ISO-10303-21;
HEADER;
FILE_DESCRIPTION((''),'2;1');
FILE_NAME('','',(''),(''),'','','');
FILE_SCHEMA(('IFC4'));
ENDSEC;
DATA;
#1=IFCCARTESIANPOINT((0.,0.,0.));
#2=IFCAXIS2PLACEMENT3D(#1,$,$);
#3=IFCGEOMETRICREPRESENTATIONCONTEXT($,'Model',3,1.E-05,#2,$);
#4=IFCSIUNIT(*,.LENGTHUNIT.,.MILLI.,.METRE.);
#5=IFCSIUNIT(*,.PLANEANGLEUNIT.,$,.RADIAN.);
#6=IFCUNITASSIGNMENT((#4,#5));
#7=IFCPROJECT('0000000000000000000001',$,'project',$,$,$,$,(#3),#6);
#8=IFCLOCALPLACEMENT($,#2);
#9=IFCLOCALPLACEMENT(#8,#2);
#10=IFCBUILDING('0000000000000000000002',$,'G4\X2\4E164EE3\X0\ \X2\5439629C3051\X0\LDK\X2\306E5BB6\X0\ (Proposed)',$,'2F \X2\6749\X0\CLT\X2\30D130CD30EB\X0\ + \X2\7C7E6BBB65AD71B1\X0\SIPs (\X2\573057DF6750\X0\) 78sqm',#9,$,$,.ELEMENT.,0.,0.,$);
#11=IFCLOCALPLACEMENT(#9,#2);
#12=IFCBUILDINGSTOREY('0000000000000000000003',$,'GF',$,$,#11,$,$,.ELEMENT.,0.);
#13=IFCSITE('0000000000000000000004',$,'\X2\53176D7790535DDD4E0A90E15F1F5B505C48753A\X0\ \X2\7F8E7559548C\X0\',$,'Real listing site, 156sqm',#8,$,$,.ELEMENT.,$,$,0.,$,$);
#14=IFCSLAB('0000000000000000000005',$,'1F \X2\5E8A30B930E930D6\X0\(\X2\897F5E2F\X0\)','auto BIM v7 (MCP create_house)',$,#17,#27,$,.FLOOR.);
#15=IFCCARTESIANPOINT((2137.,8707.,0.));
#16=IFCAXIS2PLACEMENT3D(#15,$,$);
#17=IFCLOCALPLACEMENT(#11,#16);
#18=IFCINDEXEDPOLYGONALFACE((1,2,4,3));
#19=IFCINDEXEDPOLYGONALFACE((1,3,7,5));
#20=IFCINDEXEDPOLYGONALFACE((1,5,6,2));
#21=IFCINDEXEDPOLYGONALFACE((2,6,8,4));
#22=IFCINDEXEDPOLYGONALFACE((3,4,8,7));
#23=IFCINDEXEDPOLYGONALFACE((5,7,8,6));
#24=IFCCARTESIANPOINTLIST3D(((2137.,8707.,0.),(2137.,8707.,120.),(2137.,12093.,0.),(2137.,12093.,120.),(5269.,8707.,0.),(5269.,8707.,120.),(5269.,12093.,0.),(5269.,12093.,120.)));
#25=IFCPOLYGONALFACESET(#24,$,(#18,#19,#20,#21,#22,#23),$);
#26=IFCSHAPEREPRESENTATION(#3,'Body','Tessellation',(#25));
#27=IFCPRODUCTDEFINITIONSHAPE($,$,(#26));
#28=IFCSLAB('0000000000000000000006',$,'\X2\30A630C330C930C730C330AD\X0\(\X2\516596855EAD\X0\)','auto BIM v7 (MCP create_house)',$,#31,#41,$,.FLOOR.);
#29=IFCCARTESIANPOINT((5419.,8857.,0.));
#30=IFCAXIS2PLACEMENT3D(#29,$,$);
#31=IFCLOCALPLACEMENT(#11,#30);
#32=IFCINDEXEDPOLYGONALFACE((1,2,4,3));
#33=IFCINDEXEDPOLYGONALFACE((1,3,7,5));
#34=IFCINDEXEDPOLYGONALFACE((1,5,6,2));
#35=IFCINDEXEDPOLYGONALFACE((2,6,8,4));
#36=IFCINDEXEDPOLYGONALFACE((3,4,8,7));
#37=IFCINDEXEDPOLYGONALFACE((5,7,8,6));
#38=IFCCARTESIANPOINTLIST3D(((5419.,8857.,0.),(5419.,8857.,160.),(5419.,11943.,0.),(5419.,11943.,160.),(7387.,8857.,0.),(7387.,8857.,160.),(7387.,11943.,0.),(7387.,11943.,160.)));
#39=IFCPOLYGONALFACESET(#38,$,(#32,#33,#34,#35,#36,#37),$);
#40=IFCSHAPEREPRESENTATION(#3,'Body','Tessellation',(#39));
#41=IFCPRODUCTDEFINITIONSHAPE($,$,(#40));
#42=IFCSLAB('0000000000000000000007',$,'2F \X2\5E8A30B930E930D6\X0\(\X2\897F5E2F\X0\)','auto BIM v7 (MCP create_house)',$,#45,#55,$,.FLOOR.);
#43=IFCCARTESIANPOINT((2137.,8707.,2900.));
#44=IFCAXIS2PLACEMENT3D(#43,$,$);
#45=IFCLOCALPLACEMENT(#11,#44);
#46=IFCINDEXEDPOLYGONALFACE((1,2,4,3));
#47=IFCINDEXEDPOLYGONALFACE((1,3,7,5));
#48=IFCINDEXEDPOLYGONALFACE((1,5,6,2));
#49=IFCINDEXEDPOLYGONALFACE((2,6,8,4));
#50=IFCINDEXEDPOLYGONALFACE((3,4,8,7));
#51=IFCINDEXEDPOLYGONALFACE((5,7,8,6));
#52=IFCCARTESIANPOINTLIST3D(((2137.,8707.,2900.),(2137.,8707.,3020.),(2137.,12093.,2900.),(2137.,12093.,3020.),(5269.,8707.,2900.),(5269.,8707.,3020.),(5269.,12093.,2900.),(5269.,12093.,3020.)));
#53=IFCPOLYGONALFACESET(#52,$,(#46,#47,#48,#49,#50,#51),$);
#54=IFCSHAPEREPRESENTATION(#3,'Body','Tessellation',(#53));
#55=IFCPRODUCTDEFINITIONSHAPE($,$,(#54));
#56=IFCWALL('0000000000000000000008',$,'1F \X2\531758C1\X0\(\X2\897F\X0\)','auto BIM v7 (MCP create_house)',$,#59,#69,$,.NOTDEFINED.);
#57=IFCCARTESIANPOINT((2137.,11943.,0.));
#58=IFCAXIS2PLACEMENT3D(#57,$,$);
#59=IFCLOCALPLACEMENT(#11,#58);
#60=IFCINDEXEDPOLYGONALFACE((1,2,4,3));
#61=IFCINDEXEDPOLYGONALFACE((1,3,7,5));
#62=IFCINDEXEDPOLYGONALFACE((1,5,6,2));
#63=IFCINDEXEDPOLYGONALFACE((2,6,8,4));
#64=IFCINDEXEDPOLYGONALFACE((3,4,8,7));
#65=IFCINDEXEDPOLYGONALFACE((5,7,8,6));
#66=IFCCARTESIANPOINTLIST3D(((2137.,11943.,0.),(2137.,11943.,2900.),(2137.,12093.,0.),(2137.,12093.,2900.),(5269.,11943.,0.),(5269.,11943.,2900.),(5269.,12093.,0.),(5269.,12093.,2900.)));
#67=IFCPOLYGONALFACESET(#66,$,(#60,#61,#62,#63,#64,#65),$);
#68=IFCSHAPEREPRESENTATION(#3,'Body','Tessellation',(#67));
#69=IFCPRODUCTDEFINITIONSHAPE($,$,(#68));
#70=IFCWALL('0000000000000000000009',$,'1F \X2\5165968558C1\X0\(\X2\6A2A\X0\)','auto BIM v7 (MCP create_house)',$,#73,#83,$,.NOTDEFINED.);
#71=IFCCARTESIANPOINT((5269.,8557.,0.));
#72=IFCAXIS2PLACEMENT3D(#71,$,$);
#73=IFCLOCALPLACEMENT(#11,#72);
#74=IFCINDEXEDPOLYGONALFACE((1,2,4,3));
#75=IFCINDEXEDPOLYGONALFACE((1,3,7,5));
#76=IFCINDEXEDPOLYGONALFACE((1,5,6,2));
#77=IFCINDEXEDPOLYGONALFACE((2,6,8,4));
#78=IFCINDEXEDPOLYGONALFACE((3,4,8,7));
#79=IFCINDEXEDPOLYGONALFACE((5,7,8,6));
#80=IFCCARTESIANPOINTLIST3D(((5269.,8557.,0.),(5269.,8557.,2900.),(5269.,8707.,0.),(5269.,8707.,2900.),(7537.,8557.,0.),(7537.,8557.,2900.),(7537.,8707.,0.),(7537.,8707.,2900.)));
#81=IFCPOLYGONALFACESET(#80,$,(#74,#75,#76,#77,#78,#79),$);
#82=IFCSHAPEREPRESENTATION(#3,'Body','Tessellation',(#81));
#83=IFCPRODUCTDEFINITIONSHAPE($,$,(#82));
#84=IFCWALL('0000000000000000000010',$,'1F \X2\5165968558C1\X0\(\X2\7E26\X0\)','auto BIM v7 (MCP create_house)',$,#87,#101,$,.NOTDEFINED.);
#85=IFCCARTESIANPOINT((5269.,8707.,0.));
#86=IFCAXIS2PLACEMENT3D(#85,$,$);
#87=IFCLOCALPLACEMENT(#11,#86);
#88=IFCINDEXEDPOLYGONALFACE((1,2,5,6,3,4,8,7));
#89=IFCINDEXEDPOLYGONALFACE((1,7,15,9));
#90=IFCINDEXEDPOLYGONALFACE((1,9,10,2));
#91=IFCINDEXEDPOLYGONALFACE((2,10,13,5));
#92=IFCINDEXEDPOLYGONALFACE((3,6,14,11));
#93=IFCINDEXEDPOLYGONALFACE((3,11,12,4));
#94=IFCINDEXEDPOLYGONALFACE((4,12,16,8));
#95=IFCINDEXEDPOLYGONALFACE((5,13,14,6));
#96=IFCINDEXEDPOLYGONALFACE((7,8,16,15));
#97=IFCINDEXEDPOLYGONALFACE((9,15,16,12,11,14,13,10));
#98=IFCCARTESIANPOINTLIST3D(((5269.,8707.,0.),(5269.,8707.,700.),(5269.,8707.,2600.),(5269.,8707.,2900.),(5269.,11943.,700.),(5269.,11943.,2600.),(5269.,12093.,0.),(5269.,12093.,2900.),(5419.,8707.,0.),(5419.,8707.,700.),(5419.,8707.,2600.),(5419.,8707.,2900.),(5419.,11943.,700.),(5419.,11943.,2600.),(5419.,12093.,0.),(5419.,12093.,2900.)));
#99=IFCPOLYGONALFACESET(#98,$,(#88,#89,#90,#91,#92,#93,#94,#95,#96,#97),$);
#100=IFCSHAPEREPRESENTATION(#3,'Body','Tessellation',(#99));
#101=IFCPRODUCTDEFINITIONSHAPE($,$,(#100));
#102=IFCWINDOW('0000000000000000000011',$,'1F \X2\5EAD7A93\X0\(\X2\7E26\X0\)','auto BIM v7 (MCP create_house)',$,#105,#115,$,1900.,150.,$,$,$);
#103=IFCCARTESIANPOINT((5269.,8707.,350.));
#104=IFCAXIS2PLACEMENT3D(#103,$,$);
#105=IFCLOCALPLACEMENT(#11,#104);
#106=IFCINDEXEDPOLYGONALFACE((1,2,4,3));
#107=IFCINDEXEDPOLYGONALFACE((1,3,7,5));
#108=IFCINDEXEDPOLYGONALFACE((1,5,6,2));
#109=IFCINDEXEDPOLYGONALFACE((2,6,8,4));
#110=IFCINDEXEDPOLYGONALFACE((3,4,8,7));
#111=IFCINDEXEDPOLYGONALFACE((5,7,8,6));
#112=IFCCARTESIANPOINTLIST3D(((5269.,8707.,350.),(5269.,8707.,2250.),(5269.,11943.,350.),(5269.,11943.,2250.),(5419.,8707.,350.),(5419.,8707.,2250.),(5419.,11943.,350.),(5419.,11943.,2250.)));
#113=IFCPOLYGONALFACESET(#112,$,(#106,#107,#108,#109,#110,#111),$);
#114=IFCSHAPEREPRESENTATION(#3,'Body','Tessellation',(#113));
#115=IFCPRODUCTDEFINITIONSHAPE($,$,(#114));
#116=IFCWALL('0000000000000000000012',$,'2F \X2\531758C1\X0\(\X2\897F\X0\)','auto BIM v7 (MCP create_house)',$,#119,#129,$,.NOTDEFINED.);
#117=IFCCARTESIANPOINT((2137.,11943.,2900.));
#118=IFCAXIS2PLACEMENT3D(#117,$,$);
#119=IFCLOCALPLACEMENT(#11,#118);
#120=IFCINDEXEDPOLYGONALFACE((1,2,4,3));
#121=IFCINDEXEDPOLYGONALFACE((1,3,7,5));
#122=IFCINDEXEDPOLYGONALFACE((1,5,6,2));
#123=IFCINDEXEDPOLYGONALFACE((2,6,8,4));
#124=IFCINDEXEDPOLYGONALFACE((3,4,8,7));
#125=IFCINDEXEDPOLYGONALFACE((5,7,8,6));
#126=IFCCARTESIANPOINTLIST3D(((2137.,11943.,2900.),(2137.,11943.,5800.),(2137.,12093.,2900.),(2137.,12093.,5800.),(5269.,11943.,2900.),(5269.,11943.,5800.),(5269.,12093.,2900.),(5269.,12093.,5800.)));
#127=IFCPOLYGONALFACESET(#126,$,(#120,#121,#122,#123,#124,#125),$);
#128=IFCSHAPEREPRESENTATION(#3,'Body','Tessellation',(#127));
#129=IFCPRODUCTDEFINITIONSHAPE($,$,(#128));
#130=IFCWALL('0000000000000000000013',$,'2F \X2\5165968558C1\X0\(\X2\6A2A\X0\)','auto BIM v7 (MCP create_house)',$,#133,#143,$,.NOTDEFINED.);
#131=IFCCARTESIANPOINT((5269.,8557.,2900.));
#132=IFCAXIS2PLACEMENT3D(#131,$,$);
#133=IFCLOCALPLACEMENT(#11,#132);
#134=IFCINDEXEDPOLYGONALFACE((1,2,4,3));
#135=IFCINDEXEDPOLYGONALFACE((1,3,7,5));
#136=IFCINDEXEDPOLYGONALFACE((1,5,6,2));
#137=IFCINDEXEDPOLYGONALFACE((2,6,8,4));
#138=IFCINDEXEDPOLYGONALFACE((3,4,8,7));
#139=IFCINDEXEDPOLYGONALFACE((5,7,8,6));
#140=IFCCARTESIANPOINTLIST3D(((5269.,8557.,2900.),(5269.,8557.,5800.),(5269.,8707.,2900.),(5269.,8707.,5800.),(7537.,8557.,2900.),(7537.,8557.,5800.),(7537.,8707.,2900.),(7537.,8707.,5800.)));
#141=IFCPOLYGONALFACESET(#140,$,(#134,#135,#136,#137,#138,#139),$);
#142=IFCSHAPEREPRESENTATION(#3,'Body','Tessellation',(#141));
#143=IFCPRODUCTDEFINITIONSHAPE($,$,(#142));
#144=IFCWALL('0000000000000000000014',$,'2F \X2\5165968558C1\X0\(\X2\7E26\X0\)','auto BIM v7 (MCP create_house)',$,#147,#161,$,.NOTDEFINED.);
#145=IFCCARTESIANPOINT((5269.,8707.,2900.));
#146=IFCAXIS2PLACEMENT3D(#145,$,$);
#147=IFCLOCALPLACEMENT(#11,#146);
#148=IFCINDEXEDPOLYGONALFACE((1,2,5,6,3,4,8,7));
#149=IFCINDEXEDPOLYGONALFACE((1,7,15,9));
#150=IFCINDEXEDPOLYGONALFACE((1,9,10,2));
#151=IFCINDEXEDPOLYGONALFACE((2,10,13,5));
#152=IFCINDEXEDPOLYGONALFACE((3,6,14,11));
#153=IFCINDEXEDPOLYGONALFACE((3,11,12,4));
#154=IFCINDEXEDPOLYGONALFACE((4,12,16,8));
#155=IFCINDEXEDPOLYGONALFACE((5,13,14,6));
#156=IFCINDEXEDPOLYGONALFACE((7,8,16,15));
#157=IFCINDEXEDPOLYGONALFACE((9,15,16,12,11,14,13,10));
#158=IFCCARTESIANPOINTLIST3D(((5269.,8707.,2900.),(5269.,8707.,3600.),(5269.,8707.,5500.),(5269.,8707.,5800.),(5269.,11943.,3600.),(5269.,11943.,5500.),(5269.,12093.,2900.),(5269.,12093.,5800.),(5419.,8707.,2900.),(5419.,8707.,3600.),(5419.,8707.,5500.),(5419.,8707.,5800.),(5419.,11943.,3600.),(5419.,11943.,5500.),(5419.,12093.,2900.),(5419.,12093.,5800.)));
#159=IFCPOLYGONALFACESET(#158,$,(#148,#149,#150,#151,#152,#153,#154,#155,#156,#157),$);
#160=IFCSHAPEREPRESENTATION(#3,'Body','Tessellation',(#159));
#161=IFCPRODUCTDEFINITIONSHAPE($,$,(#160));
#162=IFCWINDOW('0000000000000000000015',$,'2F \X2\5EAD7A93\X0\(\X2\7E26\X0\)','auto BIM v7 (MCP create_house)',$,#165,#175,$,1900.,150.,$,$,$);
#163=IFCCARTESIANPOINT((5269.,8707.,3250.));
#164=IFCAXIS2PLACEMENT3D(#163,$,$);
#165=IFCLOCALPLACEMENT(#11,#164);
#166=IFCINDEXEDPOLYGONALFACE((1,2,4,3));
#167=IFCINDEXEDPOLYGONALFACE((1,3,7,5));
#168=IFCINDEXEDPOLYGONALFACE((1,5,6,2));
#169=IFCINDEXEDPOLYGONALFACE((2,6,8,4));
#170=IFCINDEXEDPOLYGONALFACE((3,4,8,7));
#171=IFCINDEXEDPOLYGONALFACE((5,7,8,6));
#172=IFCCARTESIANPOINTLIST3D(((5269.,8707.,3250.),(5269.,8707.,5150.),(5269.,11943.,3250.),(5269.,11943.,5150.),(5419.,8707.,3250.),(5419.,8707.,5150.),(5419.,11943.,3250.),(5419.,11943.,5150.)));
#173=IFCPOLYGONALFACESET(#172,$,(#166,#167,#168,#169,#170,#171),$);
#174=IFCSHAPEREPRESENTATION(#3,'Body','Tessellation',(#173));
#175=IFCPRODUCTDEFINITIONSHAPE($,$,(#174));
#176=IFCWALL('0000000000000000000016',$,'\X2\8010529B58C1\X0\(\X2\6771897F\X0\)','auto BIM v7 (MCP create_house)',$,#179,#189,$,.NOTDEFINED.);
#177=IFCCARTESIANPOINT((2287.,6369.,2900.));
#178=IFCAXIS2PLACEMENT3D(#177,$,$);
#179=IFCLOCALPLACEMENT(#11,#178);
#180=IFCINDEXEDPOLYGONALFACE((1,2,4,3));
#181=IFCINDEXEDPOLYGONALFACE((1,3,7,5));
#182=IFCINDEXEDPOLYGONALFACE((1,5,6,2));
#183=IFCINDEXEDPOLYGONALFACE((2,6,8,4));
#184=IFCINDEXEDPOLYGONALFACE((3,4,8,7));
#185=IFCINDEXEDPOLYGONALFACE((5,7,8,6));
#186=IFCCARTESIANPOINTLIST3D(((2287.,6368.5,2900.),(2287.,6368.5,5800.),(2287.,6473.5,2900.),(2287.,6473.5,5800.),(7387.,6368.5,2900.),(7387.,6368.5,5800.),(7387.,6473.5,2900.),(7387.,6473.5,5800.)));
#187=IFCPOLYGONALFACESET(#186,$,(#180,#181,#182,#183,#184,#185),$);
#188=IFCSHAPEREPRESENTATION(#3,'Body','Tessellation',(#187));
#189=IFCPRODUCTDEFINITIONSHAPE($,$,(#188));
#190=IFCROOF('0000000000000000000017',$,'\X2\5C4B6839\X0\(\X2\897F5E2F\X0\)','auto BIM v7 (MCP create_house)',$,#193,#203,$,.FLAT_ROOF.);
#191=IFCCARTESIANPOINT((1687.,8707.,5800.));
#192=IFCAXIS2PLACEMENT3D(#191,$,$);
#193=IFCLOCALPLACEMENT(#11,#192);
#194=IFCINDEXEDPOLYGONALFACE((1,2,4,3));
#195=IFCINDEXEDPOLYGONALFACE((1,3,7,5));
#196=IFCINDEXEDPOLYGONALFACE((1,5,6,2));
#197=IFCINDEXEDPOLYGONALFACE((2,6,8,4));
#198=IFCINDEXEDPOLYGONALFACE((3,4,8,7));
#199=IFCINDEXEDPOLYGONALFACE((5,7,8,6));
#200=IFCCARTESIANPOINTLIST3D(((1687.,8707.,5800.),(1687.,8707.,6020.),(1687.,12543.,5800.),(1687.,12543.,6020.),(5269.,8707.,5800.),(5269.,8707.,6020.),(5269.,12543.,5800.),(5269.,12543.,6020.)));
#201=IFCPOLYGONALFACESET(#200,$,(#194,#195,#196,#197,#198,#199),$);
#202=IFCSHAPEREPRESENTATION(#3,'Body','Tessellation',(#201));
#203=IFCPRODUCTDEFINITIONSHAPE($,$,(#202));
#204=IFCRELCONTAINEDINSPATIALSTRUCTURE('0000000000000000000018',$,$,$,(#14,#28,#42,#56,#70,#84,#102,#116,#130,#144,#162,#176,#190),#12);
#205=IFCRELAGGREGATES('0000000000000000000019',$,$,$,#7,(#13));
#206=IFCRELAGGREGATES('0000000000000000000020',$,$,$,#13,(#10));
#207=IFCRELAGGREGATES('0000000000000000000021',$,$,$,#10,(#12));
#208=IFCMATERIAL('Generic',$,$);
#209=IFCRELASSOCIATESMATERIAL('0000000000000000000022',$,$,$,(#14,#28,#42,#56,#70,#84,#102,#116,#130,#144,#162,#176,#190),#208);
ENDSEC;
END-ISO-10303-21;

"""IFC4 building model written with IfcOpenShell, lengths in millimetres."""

from ifc_helpers import new_model, si_unit, frame, frame_2d, origin, place, context, project, spatial, rectangle, extrude, material, element, fill, save


model = new_model("IFC4")

# Units and contexts
model_context = context("Model", 3, precision=1e-05, world=origin())
ifc_project = project(units=[si_unit("LENGTHUNIT", "METRE", prefix="MILLI"), si_unit("PLANEANGLEUNIT", "RADIAN")], contexts=[model_context])

# Site, building, storey
site_placement = place(None, origin())
site = spatial("IfcSite", under=ifc_project, at=site_placement, Name="北海道川上郡弟子屈町 美留和", ObjectType="Real listing site, 156sqm", CompositionType="ELEMENT", RefElevation=0.0)
building_placement = place(site_placement, origin())
building = spatial("IfcBuilding", under=site, at=building_placement, Name="G4世代 吹抜けLDKの家 (Proposed)", ObjectType="2F 杉CLTパネル + 籾殻断熱SIPs (地域材) 78sqm", CompositionType="ELEMENT", ElevationOfRefHeight=0.0, ElevationOfTerrain=0.0)
storey_placement = place(building_placement, origin())
storey = spatial("IfcBuildingStorey", under=building, at=storey_placement, Name="GF", CompositionType="ELEMENT", Elevation=0.0)

# Slabs
ifc_material = material(Name="Generic")
slab_1_placement = place(storey_placement, frame((2137.0, 8707.0, 0.0)))
element("IfcSlab", 1, at=slab_1_placement, inside=storey, material=ifc_material, Name="1F 床スラブ(西帯)", Description="auto BIM v7 (MCP create_house)", PredefinedType="FLOOR", context=model_context, shape_type="SweptSolid", body=[
    extrude(rectangle(XDim=3132.0, YDim=3386.0, at=frame_2d((1566.0, 1693.0))), frame((2137.0, 8707.0, 0.0)), (0.0, 0.0, 1.0), 120.0),
])
slab_2_placement = place(storey_placement, frame((5419.0, 8857.0, 0.0)))
element("IfcSlab", 2, at=slab_2_placement, inside=storey, material=ifc_material, Name="ウッドデッキ(入隅庭)", Description="auto BIM v7 (MCP create_house)", PredefinedType="FLOOR", context=model_context, shape_type="SweptSolid", body=[
    extrude(rectangle(XDim=1968.0, YDim=3086.0, at=frame_2d((984.0, 1543.0))), frame((5419.0, 8857.0, 0.0)), (0.0, 0.0, 1.0), 160.0),
])
slab_3_placement = place(storey_placement, frame((2137.0, 8707.0, 2900.0)))
element("IfcSlab", 3, at=slab_3_placement, inside=storey, material=ifc_material, Name="2F 床スラブ(西帯)", Description="auto BIM v7 (MCP create_house)", PredefinedType="FLOOR", context=model_context, shape_type="SweptSolid", body=[
    extrude(rectangle(XDim=3132.0, YDim=3386.0, at=frame_2d((1566.0, 1693.0))), frame((2137.0, 8707.0, 2900.0)), (0.0, 0.0, 1.0), 120.0),
])

# Walls
wall_1_placement = place(storey_placement, frame((2137.0, 11943.0, 0.0)))
element("IfcWall", 4, at=wall_1_placement, inside=storey, material=ifc_material, Name="1F 北壁(西)", Description="auto BIM v7 (MCP create_house)", PredefinedType="NOTDEFINED", context=model_context, shape_type="SweptSolid", body=[
    extrude(rectangle(XDim=3132.0, YDim=150.0, at=frame_2d((1566.0, 75.0))), frame((2137.0, 11943.0, 0.0)), (0.0, 0.0, 1.0), 2900.0),
])
wall_2_placement = place(storey_placement, frame((5269.0, 8557.0, 0.0)))
element("IfcWall", 5, at=wall_2_placement, inside=storey, material=ifc_material, Name="1F 入隅壁(横)", Description="auto BIM v7 (MCP create_house)", PredefinedType="NOTDEFINED", context=model_context, shape_type="SweptSolid", body=[
    extrude(rectangle(XDim=2268.0, YDim=150.0, at=frame_2d((1134.0, 75.0))), frame((5269.0, 8557.0, 0.0)), (0.0, 0.0, 1.0), 2900.0),
])

# Wall, opening, window
wall_3_placement = place(storey_placement, frame((5269.0, 8707.0, 0.0)))
wall_3 = element("IfcWall", 6, at=wall_3_placement, inside=storey, material=ifc_material, Name="1F 入隅壁(縦)", Description="auto BIM v7 (MCP create_house)", PredefinedType="NOTDEFINED", context=model_context, shape_type="SweptSolid", body=[
    extrude(rectangle(XDim=150.0, YDim=3386.0, at=frame_2d((75.0, 1693.0))), frame((5269.0, 8707.0, 0.0)), (0.0, 0.0, 1.0), 2900.0),
])
opening_1_placement = place(storey_placement, frame((5269.0, 8707.0, 350.0)))
opening_1 = element("IfcOpeningElement", 7, at=opening_1_placement, cuts=wall_3, PredefinedType="NOTDEFINED", context=model_context, shape_type="SweptSolid", body=[
    extrude(rectangle(XDim=150.0, YDim=3236.0, at=frame_2d((75.0, 1618.0))), frame((5269.0, 8707.0, 350.0)), (0.0, 0.0, 1.0), 1900.0),
])
window_1_placement = place(storey_placement, frame((5269.0, 8707.0, 350.0)))
window_1 = element("IfcWindow", 8, at=window_1_placement, inside=storey, material=ifc_material, Name="1F 庭窓(縦)", Description="auto BIM v7 (MCP create_house)", OverallHeight=1900.0, OverallWidth=150.0, context=model_context, shape_type="SweptSolid", body=[
    extrude(rectangle(XDim=150.0, YDim=3236.0, at=frame_2d((75.0, 1618.0))), frame((5269.0, 8707.0, 350.0)), (0.0, 0.0, 1.0), 1900.0),
])
fill(opening_1, window_1)

# Walls
wall_4_placement = place(storey_placement, frame((2137.0, 11943.0, 2900.0)))
element("IfcWall", 9, at=wall_4_placement, inside=storey, material=ifc_material, Name="2F 北壁(西)", Description="auto BIM v7 (MCP create_house)", PredefinedType="NOTDEFINED", context=model_context, shape_type="SweptSolid", body=[
    extrude(rectangle(XDim=3132.0, YDim=150.0, at=frame_2d((1566.0, 75.0))), frame((2137.0, 11943.0, 2900.0)), (0.0, 0.0, 1.0), 2900.0),
])
wall_5_placement = place(storey_placement, frame((5269.0, 8557.0, 2900.0)))
element("IfcWall", 10, at=wall_5_placement, inside=storey, material=ifc_material, Name="2F 入隅壁(横)", Description="auto BIM v7 (MCP create_house)", PredefinedType="NOTDEFINED", context=model_context, shape_type="SweptSolid", body=[
    extrude(rectangle(XDim=2268.0, YDim=150.0, at=frame_2d((1134.0, 75.0))), frame((5269.0, 8557.0, 2900.0)), (0.0, 0.0, 1.0), 2900.0),
])

# Wall, opening, window
wall_6_placement = place(storey_placement, frame((5269.0, 8707.0, 2900.0)))
wall_6 = element("IfcWall", 11, at=wall_6_placement, inside=storey, material=ifc_material, Name="2F 入隅壁(縦)", Description="auto BIM v7 (MCP create_house)", PredefinedType="NOTDEFINED", context=model_context, shape_type="SweptSolid", body=[
    extrude(rectangle(XDim=150.0, YDim=3386.0, at=frame_2d((75.0, 1693.0))), frame((5269.0, 8707.0, 2900.0)), (0.0, 0.0, 1.0), 2900.0),
])
opening_2_placement = place(storey_placement, frame((5269.0, 8707.0, 3250.0)))
opening_2 = element("IfcOpeningElement", 12, at=opening_2_placement, cuts=wall_6, PredefinedType="NOTDEFINED", context=model_context, shape_type="SweptSolid", body=[
    extrude(rectangle(XDim=150.0, YDim=3236.0, at=frame_2d((75.0, 1618.0))), frame((5269.0, 8707.0, 3250.0)), (0.0, 0.0, 1.0), 1900.0),
])
window_2_placement = place(storey_placement, frame((5269.0, 8707.0, 3250.0)))
window_2 = element("IfcWindow", 13, at=window_2_placement, inside=storey, material=ifc_material, Name="2F 庭窓(縦)", Description="auto BIM v7 (MCP create_house)", OverallHeight=1900.0, OverallWidth=150.0, context=model_context, shape_type="SweptSolid", body=[
    extrude(rectangle(XDim=150.0, YDim=3236.0, at=frame_2d((75.0, 1618.0))), frame((5269.0, 8707.0, 3250.0)), (0.0, 0.0, 1.0), 1900.0),
])
fill(opening_2, window_2)

# Wall
wall_7_placement = place(storey_placement, frame((2287.0, 6369.0, 2900.0)))
element("IfcWall", 14, at=wall_7_placement, inside=storey, material=ifc_material, Name="耐力壁(東西)", Description="auto BIM v7 (MCP create_house)", PredefinedType="NOTDEFINED", context=model_context, shape_type="SweptSolid", body=[
    extrude(rectangle(XDim=5100.0, YDim=105.0, at=frame_2d((2550.0, 52.0))), frame((2287.0, 6369.0, 2900.0)), (0.0, 0.0, 1.0), 2900.0),
])

# Roof
for number, where, name in (
    (15, (1687.0, 8707.0, 5800.0), "屋根(西帯)"),
):
    element("IfcRoof", number, at=place(storey_placement, frame(where)), inside=storey, material=ifc_material, Name=name, Description="auto BIM v7 (MCP create_house)", PredefinedType="FLAT_ROOF", context=model_context, shape_type="SweptSolid", body=[
        extrude(rectangle(XDim=3582.0, YDim=3836.0, at=frame_2d((1791.0, 1918.0))), frame((1687.0, 8707.0, 5800.0)), (0.0, 0.0, 1.0), 220.0),
    ])

save(model, "model.ifc")
